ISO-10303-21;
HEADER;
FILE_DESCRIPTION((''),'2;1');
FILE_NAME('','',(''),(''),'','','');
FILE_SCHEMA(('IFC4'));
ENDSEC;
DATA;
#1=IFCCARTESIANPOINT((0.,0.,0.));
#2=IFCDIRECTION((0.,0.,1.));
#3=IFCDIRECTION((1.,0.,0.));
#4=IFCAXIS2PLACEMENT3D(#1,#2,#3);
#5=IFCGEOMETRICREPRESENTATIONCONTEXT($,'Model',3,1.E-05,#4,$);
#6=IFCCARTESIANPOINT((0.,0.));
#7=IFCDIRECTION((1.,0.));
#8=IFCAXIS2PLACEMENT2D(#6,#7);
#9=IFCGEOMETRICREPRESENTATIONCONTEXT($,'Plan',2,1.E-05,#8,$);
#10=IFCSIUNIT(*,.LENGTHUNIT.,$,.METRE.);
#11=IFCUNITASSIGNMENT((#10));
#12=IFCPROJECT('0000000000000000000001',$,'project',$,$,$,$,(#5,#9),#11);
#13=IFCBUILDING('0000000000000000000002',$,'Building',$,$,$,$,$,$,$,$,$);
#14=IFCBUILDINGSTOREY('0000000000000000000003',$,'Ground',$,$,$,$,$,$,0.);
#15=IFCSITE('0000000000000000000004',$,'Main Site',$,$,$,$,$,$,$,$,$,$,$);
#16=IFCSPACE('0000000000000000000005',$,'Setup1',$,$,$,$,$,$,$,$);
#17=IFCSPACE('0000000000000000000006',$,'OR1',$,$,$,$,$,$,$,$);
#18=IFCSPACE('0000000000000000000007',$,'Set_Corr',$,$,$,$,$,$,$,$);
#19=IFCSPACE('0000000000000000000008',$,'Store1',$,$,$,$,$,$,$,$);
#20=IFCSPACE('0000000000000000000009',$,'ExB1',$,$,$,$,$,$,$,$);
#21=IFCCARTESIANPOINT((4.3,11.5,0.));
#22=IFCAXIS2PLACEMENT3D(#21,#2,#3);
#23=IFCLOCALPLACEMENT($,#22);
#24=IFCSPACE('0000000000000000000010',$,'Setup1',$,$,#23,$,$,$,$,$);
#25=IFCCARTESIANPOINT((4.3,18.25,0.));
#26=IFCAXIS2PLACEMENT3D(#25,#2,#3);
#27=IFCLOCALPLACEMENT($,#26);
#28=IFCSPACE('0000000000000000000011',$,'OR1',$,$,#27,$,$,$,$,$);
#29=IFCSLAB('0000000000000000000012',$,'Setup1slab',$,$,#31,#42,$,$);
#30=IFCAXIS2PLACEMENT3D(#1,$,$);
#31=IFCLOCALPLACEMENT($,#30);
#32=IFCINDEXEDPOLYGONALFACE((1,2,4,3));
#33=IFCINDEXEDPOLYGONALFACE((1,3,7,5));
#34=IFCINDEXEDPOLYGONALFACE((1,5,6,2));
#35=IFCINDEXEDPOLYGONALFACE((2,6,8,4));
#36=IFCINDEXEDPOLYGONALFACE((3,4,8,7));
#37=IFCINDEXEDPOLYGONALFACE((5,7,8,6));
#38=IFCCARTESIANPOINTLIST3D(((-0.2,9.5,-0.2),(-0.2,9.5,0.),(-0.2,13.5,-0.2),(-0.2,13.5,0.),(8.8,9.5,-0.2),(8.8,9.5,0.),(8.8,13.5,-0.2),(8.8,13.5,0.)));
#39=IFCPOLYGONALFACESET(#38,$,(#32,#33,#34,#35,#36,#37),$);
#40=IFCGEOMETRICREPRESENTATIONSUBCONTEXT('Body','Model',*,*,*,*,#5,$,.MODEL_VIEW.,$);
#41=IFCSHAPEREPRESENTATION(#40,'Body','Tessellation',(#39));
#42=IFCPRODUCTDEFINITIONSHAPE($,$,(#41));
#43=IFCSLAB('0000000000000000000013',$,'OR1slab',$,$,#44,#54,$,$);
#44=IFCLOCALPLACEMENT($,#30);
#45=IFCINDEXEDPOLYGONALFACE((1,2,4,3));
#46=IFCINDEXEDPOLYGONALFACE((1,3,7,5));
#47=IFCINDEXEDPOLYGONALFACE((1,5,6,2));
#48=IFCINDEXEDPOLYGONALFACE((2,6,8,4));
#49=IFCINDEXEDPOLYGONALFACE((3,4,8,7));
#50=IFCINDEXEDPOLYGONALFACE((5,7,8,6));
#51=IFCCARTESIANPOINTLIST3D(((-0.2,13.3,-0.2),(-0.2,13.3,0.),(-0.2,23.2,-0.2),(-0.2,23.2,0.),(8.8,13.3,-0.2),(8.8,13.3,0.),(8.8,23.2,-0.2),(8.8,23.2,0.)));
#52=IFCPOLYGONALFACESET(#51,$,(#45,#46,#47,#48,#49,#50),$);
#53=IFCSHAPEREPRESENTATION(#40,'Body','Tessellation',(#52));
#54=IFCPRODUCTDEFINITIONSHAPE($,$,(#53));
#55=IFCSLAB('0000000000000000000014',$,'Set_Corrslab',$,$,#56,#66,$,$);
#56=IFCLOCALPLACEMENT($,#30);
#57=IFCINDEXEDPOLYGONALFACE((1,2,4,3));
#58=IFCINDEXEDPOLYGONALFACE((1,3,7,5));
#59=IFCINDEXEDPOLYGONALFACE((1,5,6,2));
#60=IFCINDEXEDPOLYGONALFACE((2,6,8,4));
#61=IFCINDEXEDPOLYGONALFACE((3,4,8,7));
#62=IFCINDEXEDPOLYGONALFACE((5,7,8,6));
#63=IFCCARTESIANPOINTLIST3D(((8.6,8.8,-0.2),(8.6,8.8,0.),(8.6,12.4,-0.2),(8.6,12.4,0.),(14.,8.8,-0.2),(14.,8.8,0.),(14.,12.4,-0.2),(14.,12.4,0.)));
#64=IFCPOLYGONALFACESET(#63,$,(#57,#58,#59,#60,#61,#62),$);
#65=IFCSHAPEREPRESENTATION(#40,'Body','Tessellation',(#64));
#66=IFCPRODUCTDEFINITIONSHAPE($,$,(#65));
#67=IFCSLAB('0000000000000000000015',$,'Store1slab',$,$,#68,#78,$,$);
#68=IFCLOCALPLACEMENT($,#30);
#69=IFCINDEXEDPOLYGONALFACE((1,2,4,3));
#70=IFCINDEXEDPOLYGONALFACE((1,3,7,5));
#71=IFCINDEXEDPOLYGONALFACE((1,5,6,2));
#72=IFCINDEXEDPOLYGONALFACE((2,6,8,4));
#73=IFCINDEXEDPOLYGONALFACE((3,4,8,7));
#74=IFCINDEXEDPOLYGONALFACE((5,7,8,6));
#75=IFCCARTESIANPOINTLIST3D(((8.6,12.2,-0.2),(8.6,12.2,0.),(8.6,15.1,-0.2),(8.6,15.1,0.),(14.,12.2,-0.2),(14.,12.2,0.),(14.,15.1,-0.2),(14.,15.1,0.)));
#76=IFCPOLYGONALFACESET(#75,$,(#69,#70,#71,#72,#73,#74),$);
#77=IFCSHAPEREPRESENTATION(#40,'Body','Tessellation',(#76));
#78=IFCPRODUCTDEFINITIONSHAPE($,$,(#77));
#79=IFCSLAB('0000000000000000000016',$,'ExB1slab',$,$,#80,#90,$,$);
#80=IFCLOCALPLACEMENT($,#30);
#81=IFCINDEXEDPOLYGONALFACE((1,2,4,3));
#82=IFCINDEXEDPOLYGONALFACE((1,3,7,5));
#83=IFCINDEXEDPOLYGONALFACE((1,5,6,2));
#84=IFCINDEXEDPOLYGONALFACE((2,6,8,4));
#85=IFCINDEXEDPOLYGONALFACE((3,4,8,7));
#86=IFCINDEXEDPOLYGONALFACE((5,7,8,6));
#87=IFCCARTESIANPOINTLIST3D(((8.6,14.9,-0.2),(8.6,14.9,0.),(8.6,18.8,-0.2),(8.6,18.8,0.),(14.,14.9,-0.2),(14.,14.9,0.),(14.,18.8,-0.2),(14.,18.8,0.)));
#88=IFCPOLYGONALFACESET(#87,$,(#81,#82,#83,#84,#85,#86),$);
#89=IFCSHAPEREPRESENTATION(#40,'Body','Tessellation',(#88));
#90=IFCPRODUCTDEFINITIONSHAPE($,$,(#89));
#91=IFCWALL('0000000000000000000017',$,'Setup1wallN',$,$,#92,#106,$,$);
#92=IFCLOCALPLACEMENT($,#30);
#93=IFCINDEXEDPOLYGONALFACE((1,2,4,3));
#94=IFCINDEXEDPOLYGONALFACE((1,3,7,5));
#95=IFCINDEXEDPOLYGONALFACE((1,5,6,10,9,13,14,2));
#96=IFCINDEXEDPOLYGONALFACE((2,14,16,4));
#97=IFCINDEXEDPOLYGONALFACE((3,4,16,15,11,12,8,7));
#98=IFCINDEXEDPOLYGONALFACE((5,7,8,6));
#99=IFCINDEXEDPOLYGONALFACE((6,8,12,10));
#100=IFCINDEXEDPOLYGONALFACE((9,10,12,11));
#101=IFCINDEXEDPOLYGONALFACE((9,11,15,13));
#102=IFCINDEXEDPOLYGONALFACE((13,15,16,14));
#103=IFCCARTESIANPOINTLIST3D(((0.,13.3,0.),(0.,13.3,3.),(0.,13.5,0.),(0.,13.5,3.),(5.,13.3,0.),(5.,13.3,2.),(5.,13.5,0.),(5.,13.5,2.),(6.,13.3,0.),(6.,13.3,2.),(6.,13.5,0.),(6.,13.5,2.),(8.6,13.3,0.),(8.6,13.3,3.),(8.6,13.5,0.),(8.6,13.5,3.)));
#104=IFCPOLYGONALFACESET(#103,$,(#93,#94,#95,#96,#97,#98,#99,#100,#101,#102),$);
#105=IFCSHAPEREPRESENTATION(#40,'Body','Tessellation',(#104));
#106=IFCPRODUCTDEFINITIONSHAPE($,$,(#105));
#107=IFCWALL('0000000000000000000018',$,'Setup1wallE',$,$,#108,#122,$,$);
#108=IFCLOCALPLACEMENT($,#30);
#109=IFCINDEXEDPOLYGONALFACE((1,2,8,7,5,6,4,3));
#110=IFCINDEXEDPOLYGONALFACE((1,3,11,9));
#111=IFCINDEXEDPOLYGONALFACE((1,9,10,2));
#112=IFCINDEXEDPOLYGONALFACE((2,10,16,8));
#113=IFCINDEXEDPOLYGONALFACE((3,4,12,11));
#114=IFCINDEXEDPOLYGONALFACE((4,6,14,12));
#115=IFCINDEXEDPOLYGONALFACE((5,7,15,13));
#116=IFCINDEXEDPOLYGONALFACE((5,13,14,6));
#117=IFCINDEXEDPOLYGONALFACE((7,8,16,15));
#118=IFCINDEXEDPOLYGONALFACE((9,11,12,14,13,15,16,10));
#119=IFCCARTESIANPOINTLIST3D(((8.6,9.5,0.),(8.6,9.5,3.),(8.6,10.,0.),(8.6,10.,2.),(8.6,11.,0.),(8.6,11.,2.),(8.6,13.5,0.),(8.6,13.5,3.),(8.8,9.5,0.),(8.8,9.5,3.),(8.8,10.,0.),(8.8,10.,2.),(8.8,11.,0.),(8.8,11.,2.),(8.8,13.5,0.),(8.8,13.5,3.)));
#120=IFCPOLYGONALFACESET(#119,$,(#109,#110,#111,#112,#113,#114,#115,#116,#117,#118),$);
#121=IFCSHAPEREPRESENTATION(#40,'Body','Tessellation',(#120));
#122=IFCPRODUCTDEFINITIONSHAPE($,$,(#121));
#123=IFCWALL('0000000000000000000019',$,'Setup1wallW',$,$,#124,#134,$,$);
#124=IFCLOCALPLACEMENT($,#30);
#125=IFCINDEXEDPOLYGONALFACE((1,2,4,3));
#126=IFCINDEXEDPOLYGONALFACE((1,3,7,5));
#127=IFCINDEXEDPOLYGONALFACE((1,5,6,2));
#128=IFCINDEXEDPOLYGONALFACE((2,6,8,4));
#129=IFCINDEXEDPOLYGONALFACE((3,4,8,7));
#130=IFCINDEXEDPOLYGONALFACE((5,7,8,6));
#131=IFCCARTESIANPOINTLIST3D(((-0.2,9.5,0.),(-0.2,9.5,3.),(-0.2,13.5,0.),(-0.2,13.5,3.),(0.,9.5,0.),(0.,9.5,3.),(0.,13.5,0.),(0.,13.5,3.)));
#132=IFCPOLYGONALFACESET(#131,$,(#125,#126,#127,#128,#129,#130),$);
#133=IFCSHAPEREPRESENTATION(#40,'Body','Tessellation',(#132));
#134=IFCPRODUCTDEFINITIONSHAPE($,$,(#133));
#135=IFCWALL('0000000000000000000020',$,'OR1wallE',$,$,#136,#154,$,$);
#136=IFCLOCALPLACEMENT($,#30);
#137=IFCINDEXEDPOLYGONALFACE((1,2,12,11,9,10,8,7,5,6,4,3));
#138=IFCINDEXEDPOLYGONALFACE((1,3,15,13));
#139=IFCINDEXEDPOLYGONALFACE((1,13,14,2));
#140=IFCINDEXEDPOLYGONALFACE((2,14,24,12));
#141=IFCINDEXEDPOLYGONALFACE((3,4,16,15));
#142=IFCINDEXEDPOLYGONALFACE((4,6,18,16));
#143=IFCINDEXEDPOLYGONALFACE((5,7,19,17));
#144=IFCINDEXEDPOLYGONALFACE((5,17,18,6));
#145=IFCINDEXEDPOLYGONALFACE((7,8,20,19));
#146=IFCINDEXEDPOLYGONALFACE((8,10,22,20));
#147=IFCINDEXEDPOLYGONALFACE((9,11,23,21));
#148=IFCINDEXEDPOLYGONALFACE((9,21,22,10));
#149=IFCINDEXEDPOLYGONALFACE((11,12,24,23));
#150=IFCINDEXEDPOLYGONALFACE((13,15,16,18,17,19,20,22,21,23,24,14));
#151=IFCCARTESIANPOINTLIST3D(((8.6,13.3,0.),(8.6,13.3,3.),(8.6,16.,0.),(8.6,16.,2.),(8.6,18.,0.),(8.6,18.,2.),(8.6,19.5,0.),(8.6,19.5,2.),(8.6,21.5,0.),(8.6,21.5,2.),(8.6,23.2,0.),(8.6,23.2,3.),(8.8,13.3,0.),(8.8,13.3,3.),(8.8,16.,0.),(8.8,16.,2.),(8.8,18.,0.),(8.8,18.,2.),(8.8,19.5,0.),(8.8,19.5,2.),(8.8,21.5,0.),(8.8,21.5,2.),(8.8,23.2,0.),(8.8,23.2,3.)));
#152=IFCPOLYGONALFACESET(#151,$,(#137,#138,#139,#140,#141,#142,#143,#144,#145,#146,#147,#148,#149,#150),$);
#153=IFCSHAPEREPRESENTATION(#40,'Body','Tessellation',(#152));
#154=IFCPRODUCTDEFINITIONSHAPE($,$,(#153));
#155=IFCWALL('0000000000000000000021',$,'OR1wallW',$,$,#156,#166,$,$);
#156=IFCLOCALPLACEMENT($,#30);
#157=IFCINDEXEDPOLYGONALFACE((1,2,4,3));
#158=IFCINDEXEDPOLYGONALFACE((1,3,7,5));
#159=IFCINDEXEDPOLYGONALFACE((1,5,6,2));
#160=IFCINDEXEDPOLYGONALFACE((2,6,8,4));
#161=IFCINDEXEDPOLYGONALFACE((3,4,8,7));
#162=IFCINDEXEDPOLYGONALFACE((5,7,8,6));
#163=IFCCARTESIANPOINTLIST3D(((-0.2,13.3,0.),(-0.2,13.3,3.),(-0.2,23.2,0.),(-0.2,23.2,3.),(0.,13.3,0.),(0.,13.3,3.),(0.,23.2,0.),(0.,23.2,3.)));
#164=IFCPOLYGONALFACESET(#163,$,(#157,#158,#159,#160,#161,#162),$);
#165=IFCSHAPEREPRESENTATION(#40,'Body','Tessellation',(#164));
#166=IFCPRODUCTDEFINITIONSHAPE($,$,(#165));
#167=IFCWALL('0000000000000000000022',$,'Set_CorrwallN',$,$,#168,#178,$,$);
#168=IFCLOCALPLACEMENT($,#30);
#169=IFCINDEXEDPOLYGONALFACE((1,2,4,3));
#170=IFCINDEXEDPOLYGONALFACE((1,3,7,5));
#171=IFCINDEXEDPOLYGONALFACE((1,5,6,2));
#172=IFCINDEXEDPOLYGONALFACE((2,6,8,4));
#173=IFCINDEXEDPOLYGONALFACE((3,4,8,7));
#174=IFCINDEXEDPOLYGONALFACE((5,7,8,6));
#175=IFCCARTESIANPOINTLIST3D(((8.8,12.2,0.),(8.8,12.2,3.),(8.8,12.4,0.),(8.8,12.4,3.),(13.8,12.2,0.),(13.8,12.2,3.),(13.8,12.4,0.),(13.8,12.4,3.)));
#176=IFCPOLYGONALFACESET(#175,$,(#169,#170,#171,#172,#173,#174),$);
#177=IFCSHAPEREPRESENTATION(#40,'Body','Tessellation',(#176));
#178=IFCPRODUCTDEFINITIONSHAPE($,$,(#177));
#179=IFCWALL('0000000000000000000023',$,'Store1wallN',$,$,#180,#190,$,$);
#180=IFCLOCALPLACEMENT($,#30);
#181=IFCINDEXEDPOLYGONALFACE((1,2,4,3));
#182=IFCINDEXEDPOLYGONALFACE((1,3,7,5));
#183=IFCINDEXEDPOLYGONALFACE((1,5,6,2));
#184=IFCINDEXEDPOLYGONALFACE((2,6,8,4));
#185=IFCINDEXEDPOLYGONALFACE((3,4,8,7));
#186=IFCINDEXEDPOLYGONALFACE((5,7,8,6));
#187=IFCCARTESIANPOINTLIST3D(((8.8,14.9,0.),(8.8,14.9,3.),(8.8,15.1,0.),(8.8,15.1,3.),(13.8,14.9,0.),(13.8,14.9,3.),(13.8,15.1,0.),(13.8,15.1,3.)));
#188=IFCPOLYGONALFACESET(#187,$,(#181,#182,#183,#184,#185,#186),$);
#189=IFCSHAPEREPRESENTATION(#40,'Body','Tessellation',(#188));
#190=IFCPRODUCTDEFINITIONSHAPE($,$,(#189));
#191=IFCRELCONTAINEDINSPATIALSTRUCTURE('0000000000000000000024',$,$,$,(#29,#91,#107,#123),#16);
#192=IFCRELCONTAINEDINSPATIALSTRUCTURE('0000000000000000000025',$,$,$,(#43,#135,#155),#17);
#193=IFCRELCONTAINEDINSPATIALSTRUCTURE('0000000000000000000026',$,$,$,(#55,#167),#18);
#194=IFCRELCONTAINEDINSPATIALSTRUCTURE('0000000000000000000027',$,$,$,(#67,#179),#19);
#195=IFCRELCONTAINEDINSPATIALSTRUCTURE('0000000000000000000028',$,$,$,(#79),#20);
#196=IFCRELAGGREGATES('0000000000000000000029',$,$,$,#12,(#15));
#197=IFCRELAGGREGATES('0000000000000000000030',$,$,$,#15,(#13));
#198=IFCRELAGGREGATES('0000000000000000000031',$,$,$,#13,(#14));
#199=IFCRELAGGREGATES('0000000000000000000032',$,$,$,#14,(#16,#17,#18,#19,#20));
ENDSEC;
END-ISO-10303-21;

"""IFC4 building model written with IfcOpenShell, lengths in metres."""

from ifc_helpers import new_model, si_unit, frame, origin_with_axes, origin_2d_with_axis, place, context, subcontext, project, spatial, indexed_curve, rectangle, outline, extrude, element, save


model = new_model("IFC4")

# Units and contexts
model_context = context("Model", 3, precision=1e-05, world=origin_with_axes())
plan_context = context("Plan", 2, precision=1e-05, world=origin_2d_with_axis())
body_context = subcontext(model_context, "Body", "Model", "MODEL_VIEW")
ifc_project = project(units=[si_unit("LENGTHUNIT", "METRE")], contexts=[model_context, plan_context])

# Site, building, storey, space
site = spatial("IfcSite", under=ifc_project, Name="Main Site")
building = spatial("IfcBuilding", under=site, Name="Building")
storey = spatial("IfcBuildingStorey", under=building, Name="Ground", Elevation=0.0)
space_1 = spatial("IfcSpace", under=storey, Name="Setup1")

# Slab
slab_1_placement = place(None, frame((4.3, 11.5, -0.2), z_axis=(0.0, 0.0, 1.0), x_axis=(1.0, 0.0, 0.0)))
element("IfcSlab", 1, at=slab_1_placement, inside=space_1, Name="Setup1slab", context=body_context, shape_type="SweptSolid", body=[
    extrude(rectangle(XDim=9.0, YDim=4.0), origin_with_axes(), (0.0, 0.0, 1.0), 0.2),
])

# Shared definitions
space_2 = spatial("IfcSpace", under=storey, Name="OR1")

# Slab
slab_2_placement = place(None, frame((4.3, 18.25, -0.2), z_axis=(0.0, 0.0, 1.0), x_axis=(1.0, 0.0, 0.0)))
element("IfcSlab", 2, at=slab_2_placement, inside=space_2, Name="OR1slab", context=body_context, shape_type="SweptSolid", body=[
    extrude(rectangle(XDim=9.0, YDim=9.9), origin_with_axes(), (0.0, 0.0, 1.0), 0.2),
])

# Shared definitions
space_3 = spatial("IfcSpace", under=storey, Name="Set_Corr")

# Slab
slab_3_placement = place(None, frame((11.3, 10.6, -0.2), z_axis=(0.0, 0.0, 1.0), x_axis=(1.0, 0.0, 0.0)))
element("IfcSlab", 3, at=slab_3_placement, inside=space_3, Name="Set_Corrslab", context=body_context, shape_type="SweptSolid", body=[
    extrude(rectangle(XDim=5.4, YDim=3.6), origin_with_axes(), (0.0, 0.0, 1.0), 0.2),
])

# Shared definitions
space_4 = spatial("IfcSpace", under=storey, Name="Store1")

# Slab
slab_4_placement = place(None, frame((11.3, 13.65, -0.2), z_axis=(0.0, 0.0, 1.0), x_axis=(1.0, 0.0, 0.0)))
element("IfcSlab", 4, at=slab_4_placement, inside=space_4, Name="Store1slab", context=body_context, shape_type="SweptSolid", body=[
    extrude(rectangle(XDim=5.4, YDim=2.9), origin_with_axes(), (0.0, 0.0, 1.0), 0.2),
])

# Shared definitions
space_5 = spatial("IfcSpace", under=storey, Name="ExB1")

# Slab
slab_5_placement = place(None, frame((11.3, 16.85, -0.2), z_axis=(0.0, 0.0, 1.0), x_axis=(1.0, 0.0, 0.0)))
element("IfcSlab", 5, at=slab_5_placement, inside=space_5, Name="ExB1slab", context=body_context, shape_type="SweptSolid", body=[
    extrude(rectangle(XDim=5.4, YDim=3.9), origin_with_axes(), (0.0, 0.0, 1.0), 0.2),
])

# Wall
wall_1_placement = place(None, frame((0.0, 13.3, 0.0), z_axis=(0.0, 0.0, 1.0), x_axis=(1.0, 0.0, 0.0)))
wall_1 = element("IfcWall", 6, at=wall_1_placement, inside=space_1, Name="Setup1wallN", context=body_context, shape_type="SweptSolid", body=[
    extrude(outline(indexed_curve([(0.0, 0.0), (0.0, 0.2), (8.6, 0.2), (8.6, 0.0), (0.0, 0.0)], self_intersect=False)), origin_with_axes(), (0.0, 0.0, 1.0), 3.0),
])

# Shared definitions
space_6_placement = place(None, frame((4.3, 11.5, 0.0), z_axis=(0.0, 0.0, 1.0), x_axis=(1.0, 0.0, 0.0)))
space_6 = spatial("IfcSpace", at=space_6_placement, Name="Setup1")

# Opening
opening_1_placement = place(wall_1_placement, frame((5.0, 0.0, 0.0), z_axis=(0.0, 0.0, 1.0), x_axis=(1.0, 0.0, 0.0)))
element("IfcOpeningElement", 7, at=opening_1_placement, inside=space_6, cuts=wall_1, context=body_context, shape_type="SweptSolid", body=[
    extrude(outline(indexed_curve([(0.0, 0.0), (0.0, 0.4), (1.0, 0.4), (1.0, 0.0), (0.0, 0.0)], self_intersect=False)), origin_with_axes(), (0.0, 0.0, 1.0), 2.0),
])

# Wall, opening
wall_2_placement = place(None, frame((8.8, 9.5, 0.0), z_axis=(0.0, 0.0, 1.0), x_axis=(0.0, 1.0, 0.0)))
wall_2 = element("IfcWall", 8, at=wall_2_placement, inside=space_1, Name="Setup1wallE", context=body_context, shape_type="SweptSolid", body=[
    extrude(outline(indexed_curve([(0.0, 0.0), (0.0, 0.2), (4.0, 0.2), (4.0, 0.0), (0.0, 0.0)], self_intersect=False)), origin_with_axes(), (0.0, 0.0, 1.0), 3.0),
])
opening_2_placement = place(wall_2_placement, frame((0.5, 0.0, 0.0), z_axis=(0.0, 0.0, 1.0), x_axis=(1.0, 0.0, 0.0)))
element("IfcOpeningElement", 9, at=opening_2_placement, inside=space_6, cuts=wall_2, context=body_context, shape_type="SweptSolid", body=[
    extrude(outline(indexed_curve([(0.0, 0.0), (0.0, 0.4), (1.0, 0.4), (1.0, 0.0), (0.0, 0.0)], self_intersect=False)), origin_with_axes(), (0.0, 0.0, 1.0), 2.0),
])

# Wall
wall_3_placement = place(None, frame((0.0, 9.5, 0.0), z_axis=(0.0, 0.0, 1.0), x_axis=(0.0, 1.0, 0.0)))
element("IfcWall", 10, at=wall_3_placement, inside=space_1, Name="Setup1wallW", context=body_context, shape_type="SweptSolid", body=[
    extrude(outline(indexed_curve([(0.0, 0.0), (0.0, 0.2), (4.0, 0.2), (4.0, 0.0), (0.0, 0.0)], self_intersect=False)), origin_with_axes(), (0.0, 0.0, 1.0), 3.0),
])

# Shared definitions
space_7_placement = place(None, frame((4.3, 18.25, 0.0), z_axis=(0.0, 0.0, 1.0), x_axis=(1.0, 0.0, 0.0)))
space_7 = spatial("IfcSpace", at=space_7_placement, Name="OR1")

# Wall, openings
wall_4_placement = place(None, frame((8.8, 13.3, 0.0), z_axis=(0.0, 0.0, 1.0), x_axis=(0.0, 1.0, 0.0)))
wall_4 = element("IfcWall", 11, at=wall_4_placement, inside=space_2, Name="OR1wallE", context=body_context, shape_type="SweptSolid", body=[
    extrude(outline(indexed_curve([(0.0, 0.0), (0.0, 0.2), (9.9, 0.2), (9.9, 0.0), (0.0, 0.0)], self_intersect=False)), origin_with_axes(), (0.0, 0.0, 1.0), 3.0),
])
opening_3_placement = place(wall_4_placement, frame((2.7, 0.0, 0.0), z_axis=(0.0, 0.0, 1.0), x_axis=(1.0, 0.0, 0.0)))
element("IfcOpeningElement", 12, at=opening_3_placement, inside=space_7, cuts=wall_4, context=body_context, shape_type="SweptSolid", body=[
    extrude(outline(indexed_curve([(0.0, 0.0), (0.0, 0.4), (2.0, 0.4), (2.0, 0.0), (0.0, 0.0)], self_intersect=False)), origin_with_axes(), (0.0, 0.0, 1.0), 2.0),
])
opening_4_placement = place(wall_4_placement, frame((6.2, 0.0, 0.0), z_axis=(0.0, 0.0, 1.0), x_axis=(1.0, 0.0, 0.0)))
element("IfcOpeningElement", 13, at=opening_4_placement, inside=space_7, cuts=wall_4, context=body_context, shape_type="SweptSolid", body=[
    extrude(outline(indexed_curve([(0.0, 0.0), (0.0, 0.4), (2.0, 0.4), (2.0, 0.0), (0.0, 0.0)], self_intersect=False)), origin_with_axes(), (0.0, 0.0, 1.0), 2.0),
])

# Walls
wall_5_placement = place(None, frame((0.0, 13.3, 0.0), z_axis=(0.0, 0.0, 1.0), x_axis=(0.0, 1.0, 0.0)))
element("IfcWall", 14, at=wall_5_placement, inside=space_2, Name="OR1wallW", context=body_context, shape_type="SweptSolid", body=[
    extrude(outline(indexed_curve([(0.0, 0.0), (0.0, 0.2), (9.9, 0.2), (9.9, 0.0), (0.0, 0.0)], self_intersect=False)), origin_with_axes(), (0.0, 0.0, 1.0), 3.0),
])
wall_6_placement = place(None, frame((8.8, 12.2, 0.0), z_axis=(0.0, 0.0, 1.0), x_axis=(1.0, 0.0, 0.0)))
element("IfcWall", 15, at=wall_6_placement, inside=space_3, Name="Set_CorrwallN", context=body_context, shape_type="SweptSolid", body=[
    extrude(outline(indexed_curve([(0.0, 0.0), (0.0, 0.2), (5.0, 0.2), (5.0, 0.0), (0.0, 0.0)], self_intersect=False)), origin_with_axes(), (0.0, 0.0, 1.0), 3.0),
])
for number, where, z_axis, x_axis, name in (
    (16, (8.8, 14.9, 0.0), (0.0, 0.0, 1.0), (1.0, 0.0, 0.0), "Store1wallN"),
):
    element("IfcWall", number, at=place(None, frame(where, z_axis=z_axis, x_axis=x_axis)), inside=space_4, Name=name, context=body_context, shape_type="SweptSolid", body=[
        extrude(outline(indexed_curve([(0.0, 0.0), (0.0, 0.2), (5.0, 0.2), (5.0, 0.0), (0.0, 0.0)], self_intersect=False)), origin_with_axes(), (0.0, 0.0, 1.0), 3.0),
    ])

save(model, "model.ifc")
